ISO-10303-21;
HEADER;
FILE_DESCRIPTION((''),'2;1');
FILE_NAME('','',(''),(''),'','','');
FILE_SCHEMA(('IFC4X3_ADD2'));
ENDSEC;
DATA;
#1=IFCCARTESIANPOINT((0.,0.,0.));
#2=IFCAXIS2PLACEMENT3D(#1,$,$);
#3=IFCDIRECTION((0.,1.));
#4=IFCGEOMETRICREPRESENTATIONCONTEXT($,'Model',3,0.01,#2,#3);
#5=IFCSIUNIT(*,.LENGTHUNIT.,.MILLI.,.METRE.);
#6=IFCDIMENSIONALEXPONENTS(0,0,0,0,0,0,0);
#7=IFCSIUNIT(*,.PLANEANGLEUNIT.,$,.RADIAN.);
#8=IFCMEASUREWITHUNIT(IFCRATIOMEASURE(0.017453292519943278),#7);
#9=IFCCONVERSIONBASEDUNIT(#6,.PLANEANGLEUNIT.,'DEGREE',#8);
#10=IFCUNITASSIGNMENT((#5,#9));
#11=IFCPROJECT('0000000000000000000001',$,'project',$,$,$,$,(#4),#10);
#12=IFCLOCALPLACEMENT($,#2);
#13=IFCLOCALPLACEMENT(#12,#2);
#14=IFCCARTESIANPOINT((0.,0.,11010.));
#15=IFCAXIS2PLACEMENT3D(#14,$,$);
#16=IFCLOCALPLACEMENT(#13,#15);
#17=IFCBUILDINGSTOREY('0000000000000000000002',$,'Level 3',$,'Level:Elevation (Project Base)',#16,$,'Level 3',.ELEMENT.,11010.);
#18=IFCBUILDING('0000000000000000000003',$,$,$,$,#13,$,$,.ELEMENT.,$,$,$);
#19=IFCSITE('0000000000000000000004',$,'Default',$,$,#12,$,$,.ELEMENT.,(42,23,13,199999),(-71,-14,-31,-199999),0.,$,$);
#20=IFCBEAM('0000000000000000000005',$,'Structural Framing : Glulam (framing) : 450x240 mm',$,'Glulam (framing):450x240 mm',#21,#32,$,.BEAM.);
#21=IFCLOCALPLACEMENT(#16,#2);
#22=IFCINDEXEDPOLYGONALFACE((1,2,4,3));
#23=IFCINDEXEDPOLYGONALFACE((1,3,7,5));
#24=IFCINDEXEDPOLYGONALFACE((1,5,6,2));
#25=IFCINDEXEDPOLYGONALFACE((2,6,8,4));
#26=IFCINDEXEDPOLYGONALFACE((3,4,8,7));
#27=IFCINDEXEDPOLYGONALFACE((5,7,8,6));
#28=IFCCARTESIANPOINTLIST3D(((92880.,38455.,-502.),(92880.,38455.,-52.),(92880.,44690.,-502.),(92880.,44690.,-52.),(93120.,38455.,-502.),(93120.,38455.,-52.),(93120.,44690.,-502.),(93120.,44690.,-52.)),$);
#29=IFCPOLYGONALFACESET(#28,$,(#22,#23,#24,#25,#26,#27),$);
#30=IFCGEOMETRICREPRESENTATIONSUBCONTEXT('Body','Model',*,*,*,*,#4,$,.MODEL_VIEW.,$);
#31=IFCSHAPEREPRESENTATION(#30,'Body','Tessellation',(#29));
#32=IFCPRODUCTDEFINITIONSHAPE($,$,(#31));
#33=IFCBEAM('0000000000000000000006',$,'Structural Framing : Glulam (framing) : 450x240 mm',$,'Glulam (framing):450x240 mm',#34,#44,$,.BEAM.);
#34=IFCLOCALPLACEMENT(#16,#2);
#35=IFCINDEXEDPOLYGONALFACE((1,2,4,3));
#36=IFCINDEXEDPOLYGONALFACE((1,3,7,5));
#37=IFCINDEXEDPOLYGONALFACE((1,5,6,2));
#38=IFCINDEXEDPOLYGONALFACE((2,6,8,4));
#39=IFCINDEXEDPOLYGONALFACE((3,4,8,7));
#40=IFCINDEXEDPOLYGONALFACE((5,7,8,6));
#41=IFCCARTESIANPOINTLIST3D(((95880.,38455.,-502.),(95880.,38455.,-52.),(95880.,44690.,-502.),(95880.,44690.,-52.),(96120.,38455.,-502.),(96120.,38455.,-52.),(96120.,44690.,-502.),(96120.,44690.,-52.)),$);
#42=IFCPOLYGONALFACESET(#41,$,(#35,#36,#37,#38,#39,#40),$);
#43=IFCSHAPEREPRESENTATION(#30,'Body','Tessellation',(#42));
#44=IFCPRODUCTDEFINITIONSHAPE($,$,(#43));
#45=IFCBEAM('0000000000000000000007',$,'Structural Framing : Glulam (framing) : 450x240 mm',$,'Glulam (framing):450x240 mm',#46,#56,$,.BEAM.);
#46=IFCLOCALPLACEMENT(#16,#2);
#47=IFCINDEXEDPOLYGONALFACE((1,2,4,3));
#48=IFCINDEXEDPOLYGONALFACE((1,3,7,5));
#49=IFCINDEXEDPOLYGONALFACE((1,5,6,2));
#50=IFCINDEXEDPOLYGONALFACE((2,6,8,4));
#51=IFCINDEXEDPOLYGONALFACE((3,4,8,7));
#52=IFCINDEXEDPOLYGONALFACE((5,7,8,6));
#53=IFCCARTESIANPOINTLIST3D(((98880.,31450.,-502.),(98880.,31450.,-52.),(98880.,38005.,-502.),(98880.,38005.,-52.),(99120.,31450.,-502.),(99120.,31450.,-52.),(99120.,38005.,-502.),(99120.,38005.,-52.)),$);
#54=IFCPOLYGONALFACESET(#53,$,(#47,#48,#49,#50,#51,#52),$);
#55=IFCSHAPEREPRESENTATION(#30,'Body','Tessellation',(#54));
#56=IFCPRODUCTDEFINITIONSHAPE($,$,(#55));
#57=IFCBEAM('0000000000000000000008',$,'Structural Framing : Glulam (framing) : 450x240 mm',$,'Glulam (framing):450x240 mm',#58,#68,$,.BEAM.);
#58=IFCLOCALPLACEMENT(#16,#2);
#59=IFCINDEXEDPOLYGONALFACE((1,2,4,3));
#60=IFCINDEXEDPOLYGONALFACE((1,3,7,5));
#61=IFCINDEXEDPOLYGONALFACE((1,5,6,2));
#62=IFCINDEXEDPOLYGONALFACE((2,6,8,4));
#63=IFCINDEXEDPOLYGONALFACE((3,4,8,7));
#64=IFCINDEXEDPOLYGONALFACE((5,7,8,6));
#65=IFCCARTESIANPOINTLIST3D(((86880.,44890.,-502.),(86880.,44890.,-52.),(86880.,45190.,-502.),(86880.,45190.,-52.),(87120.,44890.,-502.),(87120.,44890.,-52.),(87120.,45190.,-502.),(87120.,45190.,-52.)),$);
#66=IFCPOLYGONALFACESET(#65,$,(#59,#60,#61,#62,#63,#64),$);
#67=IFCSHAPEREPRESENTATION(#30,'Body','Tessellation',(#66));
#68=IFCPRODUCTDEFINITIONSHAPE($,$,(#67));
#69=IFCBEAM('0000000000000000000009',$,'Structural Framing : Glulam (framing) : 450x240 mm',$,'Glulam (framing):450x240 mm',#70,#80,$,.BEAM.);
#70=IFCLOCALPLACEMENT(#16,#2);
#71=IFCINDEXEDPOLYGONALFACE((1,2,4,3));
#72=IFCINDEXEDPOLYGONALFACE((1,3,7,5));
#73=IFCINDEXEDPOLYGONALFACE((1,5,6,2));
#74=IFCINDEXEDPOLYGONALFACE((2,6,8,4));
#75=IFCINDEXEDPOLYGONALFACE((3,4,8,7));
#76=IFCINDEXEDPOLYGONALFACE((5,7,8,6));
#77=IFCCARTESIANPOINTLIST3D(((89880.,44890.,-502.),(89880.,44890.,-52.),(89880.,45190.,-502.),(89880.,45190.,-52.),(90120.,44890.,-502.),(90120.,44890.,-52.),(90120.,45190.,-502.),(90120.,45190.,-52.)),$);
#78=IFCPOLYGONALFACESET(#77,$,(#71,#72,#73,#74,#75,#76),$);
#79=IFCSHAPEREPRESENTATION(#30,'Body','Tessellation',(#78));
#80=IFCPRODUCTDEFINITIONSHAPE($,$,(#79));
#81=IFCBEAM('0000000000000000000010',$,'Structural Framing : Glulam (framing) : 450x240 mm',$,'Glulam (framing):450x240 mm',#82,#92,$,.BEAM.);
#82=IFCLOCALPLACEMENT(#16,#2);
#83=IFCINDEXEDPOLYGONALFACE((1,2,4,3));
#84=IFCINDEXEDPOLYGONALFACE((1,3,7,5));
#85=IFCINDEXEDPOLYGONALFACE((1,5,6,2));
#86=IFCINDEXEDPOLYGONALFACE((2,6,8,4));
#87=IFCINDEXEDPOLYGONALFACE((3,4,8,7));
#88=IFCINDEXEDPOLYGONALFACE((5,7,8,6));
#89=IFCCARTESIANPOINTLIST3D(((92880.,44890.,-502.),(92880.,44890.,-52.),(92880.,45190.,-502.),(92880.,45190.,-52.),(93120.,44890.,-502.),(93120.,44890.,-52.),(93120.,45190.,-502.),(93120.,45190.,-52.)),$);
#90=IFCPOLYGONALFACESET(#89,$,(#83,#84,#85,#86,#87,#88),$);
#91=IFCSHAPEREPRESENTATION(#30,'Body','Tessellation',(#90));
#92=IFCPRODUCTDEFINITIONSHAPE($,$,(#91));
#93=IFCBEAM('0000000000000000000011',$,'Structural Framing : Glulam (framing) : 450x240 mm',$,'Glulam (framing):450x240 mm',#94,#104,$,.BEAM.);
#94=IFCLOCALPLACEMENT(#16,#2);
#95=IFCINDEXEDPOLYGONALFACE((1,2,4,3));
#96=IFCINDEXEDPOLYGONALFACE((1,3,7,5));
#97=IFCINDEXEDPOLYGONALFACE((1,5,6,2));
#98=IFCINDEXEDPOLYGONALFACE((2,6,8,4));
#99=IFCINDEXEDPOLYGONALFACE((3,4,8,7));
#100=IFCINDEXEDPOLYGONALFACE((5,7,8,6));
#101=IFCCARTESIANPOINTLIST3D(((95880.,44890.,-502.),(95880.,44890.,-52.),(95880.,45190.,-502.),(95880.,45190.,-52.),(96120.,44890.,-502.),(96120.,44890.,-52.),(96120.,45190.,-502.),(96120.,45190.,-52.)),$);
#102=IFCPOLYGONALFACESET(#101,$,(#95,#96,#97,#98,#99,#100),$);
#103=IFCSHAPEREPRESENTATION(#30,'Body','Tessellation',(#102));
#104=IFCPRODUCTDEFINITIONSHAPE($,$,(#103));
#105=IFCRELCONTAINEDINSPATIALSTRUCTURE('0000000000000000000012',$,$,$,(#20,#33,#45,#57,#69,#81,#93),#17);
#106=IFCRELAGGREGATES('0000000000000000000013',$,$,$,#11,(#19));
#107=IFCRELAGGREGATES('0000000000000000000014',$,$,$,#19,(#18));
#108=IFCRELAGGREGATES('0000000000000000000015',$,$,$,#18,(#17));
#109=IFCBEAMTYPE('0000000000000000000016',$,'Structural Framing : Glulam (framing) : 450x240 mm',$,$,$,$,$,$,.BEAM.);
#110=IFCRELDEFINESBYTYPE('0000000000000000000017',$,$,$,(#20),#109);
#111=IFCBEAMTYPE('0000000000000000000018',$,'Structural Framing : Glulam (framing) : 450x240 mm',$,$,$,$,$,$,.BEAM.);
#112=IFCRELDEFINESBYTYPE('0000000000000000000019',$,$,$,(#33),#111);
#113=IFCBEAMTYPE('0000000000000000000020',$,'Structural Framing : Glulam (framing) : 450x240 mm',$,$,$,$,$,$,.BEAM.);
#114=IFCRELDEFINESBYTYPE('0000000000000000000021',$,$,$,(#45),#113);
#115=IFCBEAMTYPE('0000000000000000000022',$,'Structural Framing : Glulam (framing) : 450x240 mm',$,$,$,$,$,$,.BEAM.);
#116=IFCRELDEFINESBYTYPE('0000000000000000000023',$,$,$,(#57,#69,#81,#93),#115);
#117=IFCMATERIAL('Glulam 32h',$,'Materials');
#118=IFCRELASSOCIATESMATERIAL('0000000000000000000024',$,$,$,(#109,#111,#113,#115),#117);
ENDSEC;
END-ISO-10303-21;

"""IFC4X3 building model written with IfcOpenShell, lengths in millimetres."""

from ifc_helpers import new_model, entity, si_unit, converted_unit, direction, frame, origin, origin_2d_with_axis, place, context, subcontext, project, spatial, rectangle, extrude, source, transform, mapped, material, material_profile, profile_set, type_object, type_shapes, element, save


model = new_model("IFC4X3")

# Units and contexts
model_context = context("Model", 3, precision=0.01, world=origin(), true_north=direction((0.0, 1.0)))
body_context = subcontext(model_context, "Body", "Model", "MODEL_VIEW")
ifc_project = project(units=[si_unit("LENGTHUNIT", "METRE", prefix="MILLI"), converted_unit("PLANEANGLEUNIT", "DEGREE", entity("IfcRatioMeasure", 0.017453292519943278), si_unit("PLANEANGLEUNIT", "RADIAN"), dimensions=[0, 0, 0, 0, 0, 0, 0])], contexts=[model_context])

# Site, building, storey
site_placement = place(None, origin())
site = spatial("IfcSite", under=ifc_project, at=site_placement, Name="Default", CompositionType="ELEMENT", RefLatitude=(42, 23, 13, 199999), RefLongitude=(-71, -14, -31, -199999), RefElevation=0.0)
building_placement = place(site_placement, origin())
building = spatial("IfcBuilding", under=site, at=building_placement, CompositionType="ELEMENT")
storey_placement = place(building_placement, frame((0.0, 0.0, 11010.0)))
storey = spatial("IfcBuildingStorey", under=building, at=storey_placement, Name="Level 3", ObjectType="Level:Elevation (Project Base)", LongName="Level 3", CompositionType="ELEMENT", Elevation=11010.0)

# Beams
ifc_material_1 = material(Name="Glulam 32h", Category="Materials")
ifc_material_profile_1 = material_profile(ifc_material_1, rectangle(XDim=450.0, YDim=240.0, at=origin_2d_with_axis()), Name="450x240 mm")
ifc_profile_set_1 = profile_set([ifc_material_profile_1], Name="450x240 mm")
beam_type_1 = type_object("IfcBeamType", Name="Structural Framing : Glulam (framing) : 450x240 mm", PredefinedType="BEAM", material=ifc_profile_set_1)
shared_shape_1 = source(origin(), body_context, "Body", "SweptSolid", [
    extrude(rectangle(XDim=450.0, YDim=240.0, at=origin_2d_with_axis()), frame((-3236.2, 0.0, 0.0), z_axis=(1.0, 0.0, 0.0), x_axis=(0.0, 0.0, -1.0)), (0.0, 0.0, 1.0), 6235.0),
])
type_shapes(beam_type_1, [shared_shape_1])
beam_1_placement = place(storey_placement, frame((93000.0, 41453.7, -277.0), z_axis=(0.0, 0.0, 1.0), x_axis=(0.0, -1.0, 0.0)))
element("IfcBeam", 1, at=beam_1_placement, inside=storey, type_object=beam_type_1, Name="Structural Framing : Glulam (framing) : 450x240 mm", ObjectType="Glulam (framing):450x240 mm", PredefinedType="BEAM", context=body_context, shape_type="MappedRepresentation", body=[
    mapped(shared_shape_1, transform((0.0, 0.0, 0.0), scale=1.0)),
])
beam_type_2 = type_object("IfcBeamType", Name="Structural Framing : Glulam (framing) : 450x240 mm", PredefinedType="BEAM", material=ifc_profile_set_1)
shared_shape_2 = source(origin(), body_context, "Body", "SweptSolid", [
    extrude(rectangle(XDim=450.0, YDim=240.0, at=origin_2d_with_axis()), frame((-2880.0, 0.0, 0.0), z_axis=(1.0, 0.0, 0.0), x_axis=(0.0, 0.0, -1.0)), (0.0, 0.0, 1.0), 6235.0),
])
type_shapes(beam_type_2, [shared_shape_2])
beam_2_placement = place(storey_placement, frame((96000.0, 41810.0, -277.0), z_axis=(0.0, 0.0, 1.0), x_axis=(0.0, -1.0, 0.0)))
element("IfcBeam", 2, at=beam_2_placement, inside=storey, type_object=beam_type_2, Name="Structural Framing : Glulam (framing) : 450x240 mm", ObjectType="Glulam (framing):450x240 mm", PredefinedType="BEAM", context=body_context, shape_type="MappedRepresentation", body=[
    mapped(shared_shape_2, transform((0.0, 0.0, 0.0), scale=1.0)),
])
beam_type_3 = type_object("IfcBeamType", Name="Structural Framing : Glulam (framing) : 450x240 mm", PredefinedType="BEAM", material=ifc_profile_set_1)
shared_shape_3 = source(origin(), body_context, "Body", "SweptSolid", [
    extrude(rectangle(XDim=450.0, YDim=240.0, at=origin_2d_with_axis()), frame((2978.7, 0.0, 0.0), z_axis=(1.0, 0.0, 0.0), x_axis=(0.0, 0.0, -1.0)), (0.0, 0.0, 1.0), 6555.0),
])
type_shapes(beam_type_3, [shared_shape_3])
beam_3_placement = place(storey_placement, frame((99000.0, 40983.7, -277.0), z_axis=(0.0, 0.0, 1.0), x_axis=(0.0, -1.0, 0.0)))
element("IfcBeam", 3, at=beam_3_placement, inside=storey, type_object=beam_type_3, Name="Structural Framing : Glulam (framing) : 450x240 mm", ObjectType="Glulam (framing):450x240 mm", PredefinedType="BEAM", context=body_context, shape_type="MappedRepresentation", body=[
    mapped(shared_shape_3, transform((0.0, 0.0, 0.0), scale=1.0)),
])
beam_type_4 = type_object("IfcBeamType", Name="Structural Framing : Glulam (framing) : 450x240 mm", PredefinedType="BEAM", material=ifc_profile_set_1)
shared_shape_4 = source(origin(), body_context, "Body", "SweptSolid", [
    extrude(rectangle(XDim=450.0, YDim=240.0, at=origin_2d_with_axis()), frame((5043.7, 0.0, 0.0), z_axis=(1.0, 0.0, 0.0), x_axis=(0.0, 0.0, -1.0)), (0.0, 0.0, 1.0), 300.0),
])
type_shapes(beam_type_4, [shared_shape_4])
for number, where, z_axis, x_axis, name in (
    (4, (87000.0, 50233.7, -277.0), (0.0, 0.0, 1.0), (0.0, -1.0, 0.0), "Structural Framing : Glulam (framing) : 450x240 mm"),
    (5, (90000.0, 50233.7, -277.0), (0.0, 0.0, 1.0), (0.0, -1.0, 0.0), "Structural Framing : Glulam (framing) : 450x240 mm"),
    (6, (93000.0, 50233.7, -277.0), (0.0, 0.0, 1.0), (0.0, -1.0, 0.0), "Structural Framing : Glulam (framing) : 450x240 mm"),
    (7, (96000.0, 50233.7, -277.0), (0.0, 0.0, 1.0), (0.0, -1.0, 0.0), "Structural Framing : Glulam (framing) : 450x240 mm"),
):
    element("IfcBeam", number, at=place(storey_placement, frame(where, z_axis=z_axis, x_axis=x_axis)), inside=storey, type_object=beam_type_4, Name=name, ObjectType="Glulam (framing):450x240 mm", PredefinedType="BEAM", context=body_context, shape_type="MappedRepresentation", body=[
        mapped(shared_shape_4, transform((0.0, 0.0, 0.0), scale=1.0)),
    ])

save(model, "model.ifc")
